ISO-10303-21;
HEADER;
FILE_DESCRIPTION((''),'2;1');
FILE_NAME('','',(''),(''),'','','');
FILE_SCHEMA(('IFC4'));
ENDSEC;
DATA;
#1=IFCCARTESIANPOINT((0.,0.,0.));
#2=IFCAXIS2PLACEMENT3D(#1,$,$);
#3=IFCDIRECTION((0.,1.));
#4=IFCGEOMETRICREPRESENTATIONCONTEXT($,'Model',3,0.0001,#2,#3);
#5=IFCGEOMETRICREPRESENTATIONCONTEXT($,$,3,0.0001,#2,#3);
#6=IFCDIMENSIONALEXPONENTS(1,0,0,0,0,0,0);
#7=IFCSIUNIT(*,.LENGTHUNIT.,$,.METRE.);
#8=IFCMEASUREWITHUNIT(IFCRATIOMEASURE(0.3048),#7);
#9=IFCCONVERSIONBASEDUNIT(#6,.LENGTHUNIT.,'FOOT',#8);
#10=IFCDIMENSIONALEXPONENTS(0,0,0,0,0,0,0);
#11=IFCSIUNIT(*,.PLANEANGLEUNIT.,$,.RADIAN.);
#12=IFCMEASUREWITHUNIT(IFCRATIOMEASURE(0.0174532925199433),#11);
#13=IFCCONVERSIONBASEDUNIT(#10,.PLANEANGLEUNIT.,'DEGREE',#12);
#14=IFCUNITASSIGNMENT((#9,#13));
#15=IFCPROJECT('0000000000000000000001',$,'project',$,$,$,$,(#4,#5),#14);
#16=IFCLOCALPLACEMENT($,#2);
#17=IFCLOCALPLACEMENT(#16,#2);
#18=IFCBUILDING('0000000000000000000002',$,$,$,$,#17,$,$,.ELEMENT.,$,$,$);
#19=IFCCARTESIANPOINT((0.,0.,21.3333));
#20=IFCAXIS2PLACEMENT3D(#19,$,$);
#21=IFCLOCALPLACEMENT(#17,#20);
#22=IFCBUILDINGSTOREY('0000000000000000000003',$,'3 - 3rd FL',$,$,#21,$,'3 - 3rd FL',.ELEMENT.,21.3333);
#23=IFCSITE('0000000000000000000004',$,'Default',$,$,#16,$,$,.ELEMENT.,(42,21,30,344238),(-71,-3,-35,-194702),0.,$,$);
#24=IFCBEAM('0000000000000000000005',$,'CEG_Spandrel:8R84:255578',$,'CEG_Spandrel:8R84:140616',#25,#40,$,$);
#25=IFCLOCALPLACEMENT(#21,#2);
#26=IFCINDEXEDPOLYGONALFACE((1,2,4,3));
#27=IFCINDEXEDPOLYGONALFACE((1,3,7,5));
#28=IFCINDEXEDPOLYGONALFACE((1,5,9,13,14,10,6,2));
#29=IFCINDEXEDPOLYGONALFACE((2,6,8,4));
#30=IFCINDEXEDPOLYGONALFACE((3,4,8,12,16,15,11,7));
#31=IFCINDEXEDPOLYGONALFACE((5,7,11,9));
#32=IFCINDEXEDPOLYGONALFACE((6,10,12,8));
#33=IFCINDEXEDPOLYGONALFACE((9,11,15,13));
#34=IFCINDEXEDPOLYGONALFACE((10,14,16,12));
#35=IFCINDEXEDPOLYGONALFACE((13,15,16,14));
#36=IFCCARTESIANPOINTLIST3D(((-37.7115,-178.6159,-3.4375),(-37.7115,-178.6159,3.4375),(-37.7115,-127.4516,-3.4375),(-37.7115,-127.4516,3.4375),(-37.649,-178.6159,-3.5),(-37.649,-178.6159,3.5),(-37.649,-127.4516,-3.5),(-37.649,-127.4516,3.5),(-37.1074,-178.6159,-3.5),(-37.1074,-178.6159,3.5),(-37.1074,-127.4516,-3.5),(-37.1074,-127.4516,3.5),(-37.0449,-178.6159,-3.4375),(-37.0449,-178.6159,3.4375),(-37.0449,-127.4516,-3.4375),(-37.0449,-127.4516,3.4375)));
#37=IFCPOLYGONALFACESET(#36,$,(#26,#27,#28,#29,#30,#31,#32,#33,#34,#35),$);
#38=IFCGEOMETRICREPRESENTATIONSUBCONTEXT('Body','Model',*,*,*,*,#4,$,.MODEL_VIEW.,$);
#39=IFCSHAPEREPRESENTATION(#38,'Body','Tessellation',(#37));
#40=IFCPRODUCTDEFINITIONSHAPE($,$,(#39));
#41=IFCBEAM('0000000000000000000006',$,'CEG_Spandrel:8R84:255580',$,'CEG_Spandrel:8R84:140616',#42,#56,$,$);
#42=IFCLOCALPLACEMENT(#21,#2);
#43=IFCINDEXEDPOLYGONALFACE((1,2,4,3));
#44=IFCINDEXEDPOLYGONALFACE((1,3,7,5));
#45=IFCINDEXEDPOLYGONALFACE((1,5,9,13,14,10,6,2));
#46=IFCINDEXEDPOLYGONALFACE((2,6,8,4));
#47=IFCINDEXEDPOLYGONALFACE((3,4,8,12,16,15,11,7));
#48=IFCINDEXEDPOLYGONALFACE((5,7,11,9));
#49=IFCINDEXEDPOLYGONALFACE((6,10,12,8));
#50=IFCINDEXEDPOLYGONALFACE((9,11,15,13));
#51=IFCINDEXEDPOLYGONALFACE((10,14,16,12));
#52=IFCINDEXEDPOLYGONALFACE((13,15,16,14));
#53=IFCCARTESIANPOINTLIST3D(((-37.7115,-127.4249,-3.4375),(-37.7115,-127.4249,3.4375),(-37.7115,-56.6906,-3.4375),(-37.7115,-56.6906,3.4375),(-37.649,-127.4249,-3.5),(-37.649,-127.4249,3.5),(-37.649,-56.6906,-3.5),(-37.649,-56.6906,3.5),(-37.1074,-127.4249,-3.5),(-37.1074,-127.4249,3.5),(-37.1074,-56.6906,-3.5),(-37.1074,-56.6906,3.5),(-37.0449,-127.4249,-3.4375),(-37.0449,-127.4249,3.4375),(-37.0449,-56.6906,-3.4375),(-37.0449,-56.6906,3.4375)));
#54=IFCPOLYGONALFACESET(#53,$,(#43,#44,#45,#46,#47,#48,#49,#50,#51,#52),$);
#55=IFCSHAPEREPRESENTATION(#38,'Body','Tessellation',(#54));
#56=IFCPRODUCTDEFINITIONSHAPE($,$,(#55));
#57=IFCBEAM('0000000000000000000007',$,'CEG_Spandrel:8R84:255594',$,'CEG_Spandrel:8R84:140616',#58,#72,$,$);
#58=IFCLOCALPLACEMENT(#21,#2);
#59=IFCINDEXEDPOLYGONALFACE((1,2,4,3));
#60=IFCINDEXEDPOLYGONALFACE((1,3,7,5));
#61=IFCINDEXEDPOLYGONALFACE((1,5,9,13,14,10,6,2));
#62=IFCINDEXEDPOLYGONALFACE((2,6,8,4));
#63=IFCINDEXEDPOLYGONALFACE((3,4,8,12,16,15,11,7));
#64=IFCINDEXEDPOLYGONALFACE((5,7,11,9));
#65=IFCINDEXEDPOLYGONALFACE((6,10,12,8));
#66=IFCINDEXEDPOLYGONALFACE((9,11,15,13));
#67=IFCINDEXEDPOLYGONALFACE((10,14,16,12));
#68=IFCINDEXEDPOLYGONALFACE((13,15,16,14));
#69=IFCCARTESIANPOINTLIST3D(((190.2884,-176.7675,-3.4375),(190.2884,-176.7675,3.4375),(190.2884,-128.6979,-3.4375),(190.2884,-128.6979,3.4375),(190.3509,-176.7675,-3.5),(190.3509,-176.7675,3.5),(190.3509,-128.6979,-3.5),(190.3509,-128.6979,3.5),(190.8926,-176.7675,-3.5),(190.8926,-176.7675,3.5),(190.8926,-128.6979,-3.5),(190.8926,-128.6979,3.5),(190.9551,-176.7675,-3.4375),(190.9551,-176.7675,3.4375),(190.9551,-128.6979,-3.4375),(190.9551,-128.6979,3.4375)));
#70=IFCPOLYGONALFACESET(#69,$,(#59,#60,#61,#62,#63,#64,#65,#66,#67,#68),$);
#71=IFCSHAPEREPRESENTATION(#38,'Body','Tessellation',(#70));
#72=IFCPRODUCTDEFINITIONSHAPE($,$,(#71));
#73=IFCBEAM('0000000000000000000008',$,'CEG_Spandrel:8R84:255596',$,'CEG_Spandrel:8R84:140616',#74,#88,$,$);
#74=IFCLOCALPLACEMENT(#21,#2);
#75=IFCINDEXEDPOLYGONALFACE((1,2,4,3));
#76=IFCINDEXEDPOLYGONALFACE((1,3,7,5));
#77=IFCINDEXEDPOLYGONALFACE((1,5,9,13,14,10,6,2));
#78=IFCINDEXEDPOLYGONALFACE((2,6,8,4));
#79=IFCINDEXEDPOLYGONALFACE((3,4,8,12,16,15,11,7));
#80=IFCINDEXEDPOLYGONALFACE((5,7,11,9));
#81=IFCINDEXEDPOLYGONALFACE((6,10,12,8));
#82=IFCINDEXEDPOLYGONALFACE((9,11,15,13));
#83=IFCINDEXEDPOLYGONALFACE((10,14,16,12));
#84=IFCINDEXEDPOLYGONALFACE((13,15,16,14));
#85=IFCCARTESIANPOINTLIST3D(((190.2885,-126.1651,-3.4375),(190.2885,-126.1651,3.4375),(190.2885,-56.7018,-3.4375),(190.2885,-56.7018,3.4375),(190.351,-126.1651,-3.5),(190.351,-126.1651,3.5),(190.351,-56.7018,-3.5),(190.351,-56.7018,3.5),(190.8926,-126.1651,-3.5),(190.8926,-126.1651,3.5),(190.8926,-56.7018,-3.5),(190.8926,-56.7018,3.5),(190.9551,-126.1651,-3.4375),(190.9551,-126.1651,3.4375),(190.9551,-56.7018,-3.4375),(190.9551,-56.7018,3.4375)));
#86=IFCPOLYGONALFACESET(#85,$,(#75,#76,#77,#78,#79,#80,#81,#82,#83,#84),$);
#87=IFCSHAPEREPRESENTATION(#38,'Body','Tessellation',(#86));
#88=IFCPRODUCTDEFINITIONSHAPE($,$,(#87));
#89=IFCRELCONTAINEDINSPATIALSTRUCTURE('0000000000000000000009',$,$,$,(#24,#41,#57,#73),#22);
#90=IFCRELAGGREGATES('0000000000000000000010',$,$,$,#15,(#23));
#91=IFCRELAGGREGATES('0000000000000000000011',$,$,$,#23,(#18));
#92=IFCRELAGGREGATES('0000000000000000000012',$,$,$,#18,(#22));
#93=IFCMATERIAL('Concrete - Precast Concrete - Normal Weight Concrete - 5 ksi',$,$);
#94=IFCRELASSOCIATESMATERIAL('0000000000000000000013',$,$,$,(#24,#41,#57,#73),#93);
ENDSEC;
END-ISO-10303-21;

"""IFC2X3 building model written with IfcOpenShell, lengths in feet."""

from ifc_helpers import new_model, entity, si_unit, converted_unit, direction, frame, origin, place, context, subcontext, project, spatial, polyline, outline, extrude, material, element, save


model = new_model("IFC2X3")

# Units and contexts
model_context = context("Model", 3, precision=0.0001, world=origin(), true_north=direction((0.0, 1.0)))
context_of_model = context(None, 3, precision=0.0001, world=origin(), true_north=direction((0.0, 1.0)))
body_context = subcontext(model_context, "Body", "Model", "MODEL_VIEW")
ifc_project = project(units=[converted_unit("LENGTHUNIT", "FOOT", entity("IfcRatioMeasure", 0.3048), si_unit("LENGTHUNIT", "METRE"), dimensions=[1, 0, 0, 0, 0, 0, 0]), converted_unit("PLANEANGLEUNIT", "DEGREE", entity("IfcRatioMeasure", 0.0174532925199433), si_unit("PLANEANGLEUNIT", "RADIAN"), dimensions=[0, 0, 0, 0, 0, 0, 0])], contexts=[model_context, context_of_model])

# Site, building, storey
site_placement = place(None, origin())
site = spatial("IfcSite", under=ifc_project, at=site_placement, Name="Default", CompositionType="ELEMENT", RefLatitude=(42, 21, 30, 344238), RefLongitude=(-71, -3, -35, -194702), RefElevation=0.0)
building_placement = place(site_placement, origin())
building = spatial("IfcBuilding", under=site, at=building_placement, CompositionType="ELEMENT")
storey_placement = place(building_placement, frame((0.0, 0.0, 21.3333)))
storey = spatial("IfcBuildingStorey", under=building, at=storey_placement, Name="3 - 3rd FL", LongName="3 - 3rd FL", CompositionType="ELEMENT", Elevation=21.3333)

# Beams
ifc_material = material(Name="Concrete - Precast Concrete - Normal Weight Concrete - 5 ksi")
beam_1_placement = place(storey_placement, frame((-37.3782, -177.3715, 3.5), z_axis=(0.0, 0.0, 1.0), x_axis=(0.0, 1.0, 0.0)))
element("IfcBeam", 1, at=beam_1_placement, inside=storey, material=ifc_material, Name="CEG_Spandrel:8R84:255578", ObjectType="CEG_Spandrel:8R84:140616", context=body_context, shape_type="SweptSolid", body=[
    extrude(outline(polyline([(-3.4375, -0.3333), (3.4375, -0.3333), (3.5, -0.2708), (3.5, 0.2708), (3.4375, 0.3333), (-3.4375, 0.3333), (-3.5, 0.2708), (-3.5, -0.2708), (-3.4375, -0.3333)])), frame((-1.2444, 0.0, -3.5), z_axis=(1.0, 0.0, 0.0), x_axis=(0.0, 0.0, -1.0)), (0.0, 0.0, 1.0), 51.1643),
])
beam_2_placement = place(storey_placement, frame((-37.3782, -127.2882, 3.5), z_axis=(0.0, 0.0, 1.0), x_axis=(0.0, 1.0, 0.0)))
element("IfcBeam", 2, at=beam_2_placement, inside=storey, material=ifc_material, Name="CEG_Spandrel:8R84:255580", ObjectType="CEG_Spandrel:8R84:140616", context=body_context, shape_type="SweptSolid", body=[
    extrude(outline(polyline([(-3.4375, -0.3333), (3.4375, -0.3333), (3.5, -0.2708), (3.5, 0.2708), (3.4375, 0.3333), (-3.4375, 0.3333), (-3.5, 0.2708), (-3.5, -0.2708), (-3.4375, -0.3333)])), frame((-0.1368, 0.0, -3.5), z_axis=(1.0, 0.0, 0.0), x_axis=(0.0, 0.0, -1.0)), (0.0, 0.0, 1.0), 70.7343),
])
beam_3_placement = place(storey_placement, frame((190.6218, -177.3715, 3.5), z_axis=(0.0, 0.0, 1.0), x_axis=(0.0, 1.0, 0.0)))
element("IfcBeam", 3, at=beam_3_placement, inside=storey, material=ifc_material, Name="CEG_Spandrel:8R84:255594", ObjectType="CEG_Spandrel:8R84:140616", context=body_context, shape_type="SweptSolid", body=[
    extrude(outline(polyline([(-3.4375, -0.3333), (3.4375, -0.3333), (3.5, -0.2708), (3.5, 0.2708), (3.4375, 0.3333), (-3.4375, 0.3333), (-3.5, 0.2708), (-3.5, -0.2708), (-3.4375, -0.3333)])), frame((0.604, 0.0, -3.5), z_axis=(1.0, 0.0, 0.0), x_axis=(0.0, 0.0, -1.0)), (0.0, 0.0, 1.0), 48.0697),
])
beam_4_placement = place(storey_placement, frame((190.6218, -127.2882, 3.5), z_axis=(0.0, 0.0, 1.0), x_axis=(0.0, 1.0, 0.0)))
element("IfcBeam", 4, at=beam_4_placement, inside=storey, material=ifc_material, Name="CEG_Spandrel:8R84:255596", ObjectType="CEG_Spandrel:8R84:140616", context=body_context, shape_type="SweptSolid", body=[
    extrude(outline(polyline([(-3.4375, -0.3333), (3.4375, -0.3333), (3.5, -0.2708), (3.5, 0.2708), (3.4375, 0.3333), (-3.4375, 0.3333), (-3.5, 0.2708), (-3.5, -0.2708), (-3.4375, -0.3333)])), frame((1.1231, 0.0, -3.5), z_axis=(1.0, 0.0, 0.0), x_axis=(0.0, 0.0, -1.0)), (0.0, 0.0, 1.0), 69.4633),
])

save(model, "model.ifc")
